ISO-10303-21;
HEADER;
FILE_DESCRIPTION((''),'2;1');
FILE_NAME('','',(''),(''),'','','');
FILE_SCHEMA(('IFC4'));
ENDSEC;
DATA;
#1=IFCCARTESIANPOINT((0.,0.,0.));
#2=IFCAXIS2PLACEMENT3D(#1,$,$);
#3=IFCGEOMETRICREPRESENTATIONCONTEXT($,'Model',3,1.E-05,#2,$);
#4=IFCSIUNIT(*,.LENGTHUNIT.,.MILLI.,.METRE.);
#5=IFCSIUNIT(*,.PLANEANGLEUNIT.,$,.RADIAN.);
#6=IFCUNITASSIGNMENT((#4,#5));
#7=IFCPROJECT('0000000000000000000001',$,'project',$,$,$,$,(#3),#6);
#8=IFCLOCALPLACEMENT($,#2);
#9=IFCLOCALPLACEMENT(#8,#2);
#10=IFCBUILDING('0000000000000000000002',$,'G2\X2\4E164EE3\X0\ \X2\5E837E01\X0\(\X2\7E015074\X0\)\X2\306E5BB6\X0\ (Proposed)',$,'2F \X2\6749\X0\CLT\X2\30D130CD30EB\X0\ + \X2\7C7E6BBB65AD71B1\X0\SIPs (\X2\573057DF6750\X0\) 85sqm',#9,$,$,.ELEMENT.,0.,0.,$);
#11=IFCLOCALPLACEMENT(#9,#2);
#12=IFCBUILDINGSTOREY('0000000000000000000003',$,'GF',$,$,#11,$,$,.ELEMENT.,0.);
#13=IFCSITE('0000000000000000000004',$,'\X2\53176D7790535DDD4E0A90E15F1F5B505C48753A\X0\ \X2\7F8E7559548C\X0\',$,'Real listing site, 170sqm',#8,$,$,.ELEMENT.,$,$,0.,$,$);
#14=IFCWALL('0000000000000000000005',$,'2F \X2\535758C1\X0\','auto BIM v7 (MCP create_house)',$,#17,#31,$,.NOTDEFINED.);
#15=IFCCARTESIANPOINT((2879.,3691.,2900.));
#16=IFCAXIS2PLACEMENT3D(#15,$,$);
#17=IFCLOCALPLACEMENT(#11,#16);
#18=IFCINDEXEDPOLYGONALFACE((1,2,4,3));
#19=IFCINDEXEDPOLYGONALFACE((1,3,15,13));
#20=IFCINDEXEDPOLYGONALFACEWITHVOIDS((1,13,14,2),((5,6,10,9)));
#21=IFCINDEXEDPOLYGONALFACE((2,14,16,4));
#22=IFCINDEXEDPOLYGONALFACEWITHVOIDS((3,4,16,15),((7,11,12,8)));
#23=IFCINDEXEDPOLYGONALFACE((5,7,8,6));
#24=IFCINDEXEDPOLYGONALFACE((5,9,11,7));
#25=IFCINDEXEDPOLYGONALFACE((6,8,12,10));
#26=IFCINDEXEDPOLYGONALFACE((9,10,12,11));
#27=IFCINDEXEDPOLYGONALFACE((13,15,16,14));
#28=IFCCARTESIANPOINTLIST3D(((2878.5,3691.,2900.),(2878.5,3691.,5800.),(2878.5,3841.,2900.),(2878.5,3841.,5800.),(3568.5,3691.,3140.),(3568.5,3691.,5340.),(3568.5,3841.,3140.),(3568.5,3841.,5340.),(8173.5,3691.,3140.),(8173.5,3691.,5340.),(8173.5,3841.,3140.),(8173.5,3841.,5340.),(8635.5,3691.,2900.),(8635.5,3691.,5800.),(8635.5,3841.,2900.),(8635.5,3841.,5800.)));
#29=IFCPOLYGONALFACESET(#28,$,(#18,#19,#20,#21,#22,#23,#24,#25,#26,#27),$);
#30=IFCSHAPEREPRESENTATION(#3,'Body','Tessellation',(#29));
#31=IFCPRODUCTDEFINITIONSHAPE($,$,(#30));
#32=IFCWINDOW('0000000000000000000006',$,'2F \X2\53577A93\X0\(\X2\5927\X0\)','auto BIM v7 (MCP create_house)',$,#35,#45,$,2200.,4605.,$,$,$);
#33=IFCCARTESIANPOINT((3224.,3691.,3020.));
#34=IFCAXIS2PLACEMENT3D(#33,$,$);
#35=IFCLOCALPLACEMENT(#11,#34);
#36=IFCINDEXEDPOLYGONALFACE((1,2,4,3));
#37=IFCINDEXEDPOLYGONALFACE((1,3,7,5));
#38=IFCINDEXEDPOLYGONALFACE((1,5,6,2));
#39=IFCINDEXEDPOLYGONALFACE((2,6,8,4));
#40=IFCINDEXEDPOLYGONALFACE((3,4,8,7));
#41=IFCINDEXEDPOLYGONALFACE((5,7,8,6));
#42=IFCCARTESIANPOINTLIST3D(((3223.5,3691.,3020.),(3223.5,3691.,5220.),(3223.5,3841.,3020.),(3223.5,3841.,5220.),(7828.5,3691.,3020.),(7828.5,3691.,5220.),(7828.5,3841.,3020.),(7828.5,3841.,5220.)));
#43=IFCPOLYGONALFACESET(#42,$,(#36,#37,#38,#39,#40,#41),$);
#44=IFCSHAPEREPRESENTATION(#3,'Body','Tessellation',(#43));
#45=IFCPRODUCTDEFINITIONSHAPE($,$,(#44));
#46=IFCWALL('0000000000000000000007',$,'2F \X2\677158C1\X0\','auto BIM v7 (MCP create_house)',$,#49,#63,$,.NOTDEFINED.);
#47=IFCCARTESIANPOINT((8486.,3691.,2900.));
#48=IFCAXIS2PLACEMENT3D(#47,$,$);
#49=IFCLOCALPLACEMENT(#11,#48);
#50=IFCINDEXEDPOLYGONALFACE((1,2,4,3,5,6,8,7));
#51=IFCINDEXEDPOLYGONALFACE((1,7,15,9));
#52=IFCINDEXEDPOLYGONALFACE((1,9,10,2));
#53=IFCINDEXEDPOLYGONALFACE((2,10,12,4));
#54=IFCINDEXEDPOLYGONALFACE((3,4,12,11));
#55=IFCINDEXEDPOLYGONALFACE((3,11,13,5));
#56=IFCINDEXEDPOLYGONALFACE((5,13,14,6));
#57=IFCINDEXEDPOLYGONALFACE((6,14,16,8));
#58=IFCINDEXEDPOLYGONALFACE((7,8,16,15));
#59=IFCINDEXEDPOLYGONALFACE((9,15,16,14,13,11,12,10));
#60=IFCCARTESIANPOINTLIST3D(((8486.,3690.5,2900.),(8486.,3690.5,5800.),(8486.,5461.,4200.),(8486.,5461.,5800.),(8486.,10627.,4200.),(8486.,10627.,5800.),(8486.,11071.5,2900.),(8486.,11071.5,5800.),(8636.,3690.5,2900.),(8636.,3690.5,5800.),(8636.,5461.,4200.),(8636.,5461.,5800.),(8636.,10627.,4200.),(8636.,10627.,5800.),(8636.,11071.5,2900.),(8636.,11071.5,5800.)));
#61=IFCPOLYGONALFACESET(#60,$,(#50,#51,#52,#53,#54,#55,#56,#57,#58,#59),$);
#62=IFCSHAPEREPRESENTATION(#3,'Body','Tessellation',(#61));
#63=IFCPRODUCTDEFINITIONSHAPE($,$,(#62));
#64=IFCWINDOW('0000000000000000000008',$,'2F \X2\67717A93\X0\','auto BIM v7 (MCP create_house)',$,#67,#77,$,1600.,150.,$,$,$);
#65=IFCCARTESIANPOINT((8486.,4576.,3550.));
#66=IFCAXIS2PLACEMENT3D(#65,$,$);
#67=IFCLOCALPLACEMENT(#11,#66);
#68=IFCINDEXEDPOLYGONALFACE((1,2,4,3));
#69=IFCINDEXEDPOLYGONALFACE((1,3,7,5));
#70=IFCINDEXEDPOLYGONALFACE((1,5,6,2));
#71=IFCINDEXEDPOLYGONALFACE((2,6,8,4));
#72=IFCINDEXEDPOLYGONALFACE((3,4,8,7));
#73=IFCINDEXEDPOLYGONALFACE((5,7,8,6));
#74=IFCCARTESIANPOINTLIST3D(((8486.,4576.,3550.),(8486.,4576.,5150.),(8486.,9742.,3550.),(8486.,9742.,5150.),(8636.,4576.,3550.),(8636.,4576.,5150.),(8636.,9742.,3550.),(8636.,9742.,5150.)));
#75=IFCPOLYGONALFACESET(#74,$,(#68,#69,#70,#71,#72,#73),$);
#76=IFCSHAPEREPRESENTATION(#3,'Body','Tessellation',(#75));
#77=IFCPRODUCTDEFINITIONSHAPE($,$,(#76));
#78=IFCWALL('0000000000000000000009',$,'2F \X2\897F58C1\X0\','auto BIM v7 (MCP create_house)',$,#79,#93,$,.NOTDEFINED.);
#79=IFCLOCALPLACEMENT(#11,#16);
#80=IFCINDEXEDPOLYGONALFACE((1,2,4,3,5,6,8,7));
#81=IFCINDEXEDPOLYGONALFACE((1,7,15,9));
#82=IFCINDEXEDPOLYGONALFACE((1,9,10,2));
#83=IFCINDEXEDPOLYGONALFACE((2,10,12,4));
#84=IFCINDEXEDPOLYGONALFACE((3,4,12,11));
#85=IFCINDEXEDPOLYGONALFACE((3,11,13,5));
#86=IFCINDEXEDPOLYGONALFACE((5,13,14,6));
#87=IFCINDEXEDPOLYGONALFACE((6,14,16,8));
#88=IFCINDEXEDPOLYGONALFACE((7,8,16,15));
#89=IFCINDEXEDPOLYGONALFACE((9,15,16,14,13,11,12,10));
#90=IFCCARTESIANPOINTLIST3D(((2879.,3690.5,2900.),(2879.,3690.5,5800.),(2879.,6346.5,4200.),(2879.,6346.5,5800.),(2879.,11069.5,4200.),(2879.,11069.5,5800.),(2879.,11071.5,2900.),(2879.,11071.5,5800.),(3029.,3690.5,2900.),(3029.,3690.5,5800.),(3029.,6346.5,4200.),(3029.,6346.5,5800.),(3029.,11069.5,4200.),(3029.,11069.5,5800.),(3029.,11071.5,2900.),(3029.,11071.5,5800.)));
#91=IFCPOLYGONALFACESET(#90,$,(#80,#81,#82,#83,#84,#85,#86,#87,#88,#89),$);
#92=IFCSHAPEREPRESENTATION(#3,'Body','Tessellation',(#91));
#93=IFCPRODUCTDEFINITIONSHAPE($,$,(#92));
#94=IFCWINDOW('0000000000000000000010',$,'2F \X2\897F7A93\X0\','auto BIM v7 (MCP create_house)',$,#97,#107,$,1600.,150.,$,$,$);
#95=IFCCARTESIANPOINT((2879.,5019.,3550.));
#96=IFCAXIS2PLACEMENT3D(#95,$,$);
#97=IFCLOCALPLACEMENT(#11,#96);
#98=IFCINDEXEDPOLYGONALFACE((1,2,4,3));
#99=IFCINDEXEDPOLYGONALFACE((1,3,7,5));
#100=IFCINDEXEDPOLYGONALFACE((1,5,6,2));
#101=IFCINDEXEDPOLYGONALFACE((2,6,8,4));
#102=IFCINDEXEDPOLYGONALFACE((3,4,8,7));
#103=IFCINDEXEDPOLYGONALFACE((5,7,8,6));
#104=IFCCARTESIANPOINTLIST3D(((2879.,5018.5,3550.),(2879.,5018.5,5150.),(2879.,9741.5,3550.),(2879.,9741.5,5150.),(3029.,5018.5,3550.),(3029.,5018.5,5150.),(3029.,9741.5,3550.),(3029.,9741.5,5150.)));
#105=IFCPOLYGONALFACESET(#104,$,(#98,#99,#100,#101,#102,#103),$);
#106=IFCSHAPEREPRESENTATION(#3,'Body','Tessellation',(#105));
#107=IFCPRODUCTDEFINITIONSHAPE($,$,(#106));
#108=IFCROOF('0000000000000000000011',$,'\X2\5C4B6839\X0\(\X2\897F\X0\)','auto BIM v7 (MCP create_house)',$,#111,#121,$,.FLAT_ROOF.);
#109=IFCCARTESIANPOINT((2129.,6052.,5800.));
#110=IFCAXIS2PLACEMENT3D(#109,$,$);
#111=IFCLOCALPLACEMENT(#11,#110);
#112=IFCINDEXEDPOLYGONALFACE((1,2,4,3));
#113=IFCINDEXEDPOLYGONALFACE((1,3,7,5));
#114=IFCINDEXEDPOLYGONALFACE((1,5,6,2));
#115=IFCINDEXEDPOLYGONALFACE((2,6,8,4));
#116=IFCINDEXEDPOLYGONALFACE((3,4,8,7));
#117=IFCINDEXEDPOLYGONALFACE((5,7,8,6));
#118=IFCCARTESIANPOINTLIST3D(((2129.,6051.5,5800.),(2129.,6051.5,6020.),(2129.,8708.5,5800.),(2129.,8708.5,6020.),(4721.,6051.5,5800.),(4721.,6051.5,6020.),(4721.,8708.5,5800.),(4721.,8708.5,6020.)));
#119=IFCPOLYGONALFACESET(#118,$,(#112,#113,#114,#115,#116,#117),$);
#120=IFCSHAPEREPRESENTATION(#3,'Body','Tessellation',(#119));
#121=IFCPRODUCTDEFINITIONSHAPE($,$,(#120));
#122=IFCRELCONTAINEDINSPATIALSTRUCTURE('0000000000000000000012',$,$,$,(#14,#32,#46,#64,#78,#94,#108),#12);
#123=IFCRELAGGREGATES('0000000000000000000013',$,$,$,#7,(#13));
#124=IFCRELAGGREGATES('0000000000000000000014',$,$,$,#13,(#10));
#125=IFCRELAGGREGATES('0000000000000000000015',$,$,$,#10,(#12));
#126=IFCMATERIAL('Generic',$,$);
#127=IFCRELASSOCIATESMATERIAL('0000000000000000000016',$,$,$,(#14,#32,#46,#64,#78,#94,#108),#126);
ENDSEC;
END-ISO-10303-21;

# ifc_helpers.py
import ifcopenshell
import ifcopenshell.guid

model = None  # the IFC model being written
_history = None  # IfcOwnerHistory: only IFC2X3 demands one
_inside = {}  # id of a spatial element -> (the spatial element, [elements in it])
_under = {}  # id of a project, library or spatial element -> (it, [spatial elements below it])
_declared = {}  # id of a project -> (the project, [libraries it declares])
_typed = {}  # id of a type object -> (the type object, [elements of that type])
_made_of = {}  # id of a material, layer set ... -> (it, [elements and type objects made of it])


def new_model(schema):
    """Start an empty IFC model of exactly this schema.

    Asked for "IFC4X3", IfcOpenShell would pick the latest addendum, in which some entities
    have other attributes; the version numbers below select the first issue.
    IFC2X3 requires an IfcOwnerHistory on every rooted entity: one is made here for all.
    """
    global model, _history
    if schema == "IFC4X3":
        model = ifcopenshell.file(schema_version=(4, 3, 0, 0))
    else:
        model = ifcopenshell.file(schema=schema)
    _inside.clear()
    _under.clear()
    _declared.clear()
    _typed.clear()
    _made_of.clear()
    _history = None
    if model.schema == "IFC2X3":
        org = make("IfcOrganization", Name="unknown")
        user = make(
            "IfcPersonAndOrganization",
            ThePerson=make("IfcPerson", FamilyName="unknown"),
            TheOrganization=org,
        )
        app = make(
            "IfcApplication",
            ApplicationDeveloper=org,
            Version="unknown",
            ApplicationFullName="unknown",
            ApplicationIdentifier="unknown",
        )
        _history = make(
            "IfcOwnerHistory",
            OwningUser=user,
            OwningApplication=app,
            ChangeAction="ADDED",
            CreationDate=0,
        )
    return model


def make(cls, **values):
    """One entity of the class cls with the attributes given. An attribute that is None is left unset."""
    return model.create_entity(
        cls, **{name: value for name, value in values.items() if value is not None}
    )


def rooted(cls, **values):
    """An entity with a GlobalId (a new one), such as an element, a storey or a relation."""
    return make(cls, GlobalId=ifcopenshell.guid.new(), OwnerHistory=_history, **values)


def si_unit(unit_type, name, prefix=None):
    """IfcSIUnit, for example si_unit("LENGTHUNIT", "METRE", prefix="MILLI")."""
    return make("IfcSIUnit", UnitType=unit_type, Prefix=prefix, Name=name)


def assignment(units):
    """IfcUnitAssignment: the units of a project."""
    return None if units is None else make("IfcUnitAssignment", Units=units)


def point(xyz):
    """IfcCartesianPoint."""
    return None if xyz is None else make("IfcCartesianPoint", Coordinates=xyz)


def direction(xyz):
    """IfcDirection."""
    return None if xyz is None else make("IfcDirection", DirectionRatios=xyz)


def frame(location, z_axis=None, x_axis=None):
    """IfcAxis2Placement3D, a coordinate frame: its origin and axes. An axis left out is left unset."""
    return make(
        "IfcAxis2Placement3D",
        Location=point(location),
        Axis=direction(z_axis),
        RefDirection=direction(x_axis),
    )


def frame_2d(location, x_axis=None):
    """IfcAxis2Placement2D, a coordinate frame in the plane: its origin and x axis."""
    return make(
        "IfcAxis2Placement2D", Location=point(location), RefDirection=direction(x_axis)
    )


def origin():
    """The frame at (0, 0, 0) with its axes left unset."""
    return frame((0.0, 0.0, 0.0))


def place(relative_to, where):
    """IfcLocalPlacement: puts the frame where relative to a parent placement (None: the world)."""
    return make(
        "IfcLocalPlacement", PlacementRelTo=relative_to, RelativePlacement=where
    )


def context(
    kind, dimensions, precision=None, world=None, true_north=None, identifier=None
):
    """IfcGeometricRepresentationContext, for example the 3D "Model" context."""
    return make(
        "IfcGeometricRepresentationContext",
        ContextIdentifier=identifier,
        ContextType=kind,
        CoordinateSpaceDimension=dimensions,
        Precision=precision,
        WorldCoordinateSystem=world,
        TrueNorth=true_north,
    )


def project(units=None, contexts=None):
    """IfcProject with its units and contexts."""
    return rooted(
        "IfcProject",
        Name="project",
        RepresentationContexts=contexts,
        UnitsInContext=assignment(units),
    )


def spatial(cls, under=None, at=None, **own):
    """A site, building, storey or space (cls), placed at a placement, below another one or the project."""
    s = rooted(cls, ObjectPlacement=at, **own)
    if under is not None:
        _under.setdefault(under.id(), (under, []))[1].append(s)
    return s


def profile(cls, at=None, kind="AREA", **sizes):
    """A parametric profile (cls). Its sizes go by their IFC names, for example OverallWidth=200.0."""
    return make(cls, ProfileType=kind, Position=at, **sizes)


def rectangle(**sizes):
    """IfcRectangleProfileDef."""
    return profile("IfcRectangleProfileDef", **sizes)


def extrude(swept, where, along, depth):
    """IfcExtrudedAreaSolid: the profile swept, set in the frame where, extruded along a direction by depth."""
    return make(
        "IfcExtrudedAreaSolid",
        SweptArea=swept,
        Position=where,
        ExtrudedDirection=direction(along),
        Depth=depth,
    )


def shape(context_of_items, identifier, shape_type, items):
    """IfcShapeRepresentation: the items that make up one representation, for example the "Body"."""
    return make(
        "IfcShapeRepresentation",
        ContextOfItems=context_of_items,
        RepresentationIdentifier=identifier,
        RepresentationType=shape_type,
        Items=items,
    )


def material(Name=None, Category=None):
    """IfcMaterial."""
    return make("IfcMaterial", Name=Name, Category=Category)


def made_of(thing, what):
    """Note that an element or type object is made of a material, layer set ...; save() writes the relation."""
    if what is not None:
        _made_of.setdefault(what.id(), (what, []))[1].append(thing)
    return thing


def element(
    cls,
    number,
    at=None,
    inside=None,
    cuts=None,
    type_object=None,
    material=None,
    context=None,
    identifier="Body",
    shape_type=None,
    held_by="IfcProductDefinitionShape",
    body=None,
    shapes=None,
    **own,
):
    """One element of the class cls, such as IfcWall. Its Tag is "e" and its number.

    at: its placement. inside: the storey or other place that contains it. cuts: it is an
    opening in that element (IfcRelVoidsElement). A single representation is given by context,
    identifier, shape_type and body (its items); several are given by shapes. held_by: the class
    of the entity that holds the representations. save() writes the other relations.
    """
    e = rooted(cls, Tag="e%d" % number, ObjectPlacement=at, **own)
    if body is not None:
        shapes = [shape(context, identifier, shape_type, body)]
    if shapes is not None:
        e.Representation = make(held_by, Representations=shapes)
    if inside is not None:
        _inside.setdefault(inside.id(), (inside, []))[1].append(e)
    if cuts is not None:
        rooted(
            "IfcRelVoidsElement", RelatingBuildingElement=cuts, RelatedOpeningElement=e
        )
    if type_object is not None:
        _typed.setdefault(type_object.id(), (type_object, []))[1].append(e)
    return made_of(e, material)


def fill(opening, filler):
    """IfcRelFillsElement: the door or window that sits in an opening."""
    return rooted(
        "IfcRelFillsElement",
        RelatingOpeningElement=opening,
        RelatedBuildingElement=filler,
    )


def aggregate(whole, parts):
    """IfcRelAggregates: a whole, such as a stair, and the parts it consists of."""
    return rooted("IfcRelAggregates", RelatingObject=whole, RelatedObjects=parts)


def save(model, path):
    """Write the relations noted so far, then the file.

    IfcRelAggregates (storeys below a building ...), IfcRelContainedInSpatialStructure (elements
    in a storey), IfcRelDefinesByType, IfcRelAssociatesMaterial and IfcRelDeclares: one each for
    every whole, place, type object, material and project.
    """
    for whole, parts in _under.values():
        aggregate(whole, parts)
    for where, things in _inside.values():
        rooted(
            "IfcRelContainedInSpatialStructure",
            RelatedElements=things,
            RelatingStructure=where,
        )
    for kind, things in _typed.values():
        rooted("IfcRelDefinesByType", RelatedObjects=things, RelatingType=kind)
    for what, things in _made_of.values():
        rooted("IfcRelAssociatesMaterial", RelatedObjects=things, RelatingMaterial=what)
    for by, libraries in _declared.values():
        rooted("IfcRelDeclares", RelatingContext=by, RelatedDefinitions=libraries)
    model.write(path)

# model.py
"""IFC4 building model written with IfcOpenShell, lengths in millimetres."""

from ifc_helpers import new_model, si_unit, frame, frame_2d, origin, place, context, project, spatial, rectangle, extrude, material, element, fill, save


model = new_model("IFC4")

# Units and contexts
model_context = context("Model", 3, precision=1e-05, world=origin())
ifc_project = project(units=[si_unit("LENGTHUNIT", "METRE", prefix="MILLI"), si_unit("PLANEANGLEUNIT", "RADIAN")], contexts=[model_context])

# Site, building, storey
site_placement = place(None, origin())
site = spatial("IfcSite", under=ifc_project, at=site_placement, Name="北海道川上郡弟子屈町 美留和", ObjectType="Real listing site, 170sqm", CompositionType="ELEMENT", RefElevation=0.0)
building_placement = place(site_placement, origin())
building = spatial("IfcBuilding", under=site, at=building_placement, Name="G2世代 広縁(縁側)の家 (Proposed)", ObjectType="2F 杉CLTパネル + 籾殻断熱SIPs (地域材) 85sqm", CompositionType="ELEMENT", ElevationOfRefHeight=0.0, ElevationOfTerrain=0.0)
storey_placement = place(building_placement, origin())
storey = spatial("IfcBuildingStorey", under=building, at=storey_placement, Name="GF", CompositionType="ELEMENT", Elevation=0.0)

# Shared definitions
ifc_material = material(Name="Generic")

# Walls, openings, windows
wall_1_placement = place(storey_placement, frame((2879.0, 3691.0, 2900.0)))
wall_1 = element("IfcWall", 1, at=wall_1_placement, inside=storey, material=ifc_material, Name="2F 南壁", Description="auto BIM v7 (MCP create_house)", PredefinedType="NOTDEFINED", context=model_context, shape_type="SweptSolid", body=[
    extrude(rectangle(XDim=5757.0, YDim=150.0, at=frame_2d((2878.0, 75.0))), frame((2879.0, 3691.0, 2900.0)), (0.0, 0.0, 1.0), 2900.0),
])
opening_1_placement = place(storey_placement, frame((3224.0, 3691.0, 3020.0)))
opening_1 = element("IfcOpeningElement", 2, at=opening_1_placement, cuts=wall_1, PredefinedType="NOTDEFINED", context=model_context, shape_type="SweptSolid", body=[
    extrude(rectangle(XDim=4605.0, YDim=150.0, at=frame_2d((2302.0, 75.0))), frame((3224.0, 3691.0, 3020.0)), (0.0, 0.0, 1.0), 2200.0),
])
window_1_placement = place(storey_placement, frame((3224.0, 3691.0, 3020.0)))
window_1 = element("IfcWindow", 3, at=window_1_placement, inside=storey, material=ifc_material, Name="2F 南窓(大)", Description="auto BIM v7 (MCP create_house)", OverallHeight=2200.0, OverallWidth=4605.0, context=model_context, shape_type="SweptSolid", body=[
    extrude(rectangle(XDim=4605.0, YDim=150.0, at=frame_2d((2302.0, 75.0))), frame((3224.0, 3691.0, 3020.0)), (0.0, 0.0, 1.0), 2200.0),
])
fill(opening_1, window_1)
wall_2_placement = place(storey_placement, frame((8486.0, 3691.0, 2900.0)))
wall_2 = element("IfcWall", 4, at=wall_2_placement, inside=storey, material=ifc_material, Name="2F 東壁", Description="auto BIM v7 (MCP create_house)", PredefinedType="NOTDEFINED", context=model_context, shape_type="SweptSolid", body=[
    extrude(rectangle(XDim=150.0, YDim=7381.0, at=frame_2d((75.0, 3690.0))), frame((8486.0, 3691.0, 2900.0)), (0.0, 0.0, 1.0), 2900.0),
])
opening_2_placement = place(storey_placement, frame((8486.0, 4576.0, 3550.0)))
opening_2 = element("IfcOpeningElement", 5, at=opening_2_placement, cuts=wall_2, PredefinedType="NOTDEFINED", context=model_context, shape_type="SweptSolid", body=[
    extrude(rectangle(XDim=150.0, YDim=5166.0, at=frame_2d((75.0, 2583.0))), frame((8486.0, 4576.0, 3550.0)), (0.0, 0.0, 1.0), 1600.0),
])
window_2_placement = place(storey_placement, frame((8486.0, 4576.0, 3550.0)))
window_2 = element("IfcWindow", 6, at=window_2_placement, inside=storey, material=ifc_material, Name="2F 東窓", Description="auto BIM v7 (MCP create_house)", OverallHeight=1600.0, OverallWidth=150.0, context=model_context, shape_type="SweptSolid", body=[
    extrude(rectangle(XDim=150.0, YDim=5166.0, at=frame_2d((75.0, 2583.0))), frame((8486.0, 4576.0, 3550.0)), (0.0, 0.0, 1.0), 1600.0),
])
fill(opening_2, window_2)
wall_3_placement = place(storey_placement, frame((2879.0, 3691.0, 2900.0)))
wall_3 = element("IfcWall", 7, at=wall_3_placement, inside=storey, material=ifc_material, Name="2F 西壁", Description="auto BIM v7 (MCP create_house)", PredefinedType="NOTDEFINED", context=model_context, shape_type="SweptSolid", body=[
    extrude(rectangle(XDim=150.0, YDim=7381.0, at=frame_2d((75.0, 3690.0))), frame((2879.0, 3691.0, 2900.0)), (0.0, 0.0, 1.0), 2900.0),
])
opening_3_placement = place(storey_placement, frame((2879.0, 5019.0, 3550.0)))
opening_3 = element("IfcOpeningElement", 8, at=opening_3_placement, cuts=wall_3, PredefinedType="NOTDEFINED", context=model_context, shape_type="SweptSolid", body=[
    extrude(rectangle(XDim=150.0, YDim=4723.0, at=frame_2d((75.0, 2361.0))), frame((2879.0, 5019.0, 3550.0)), (0.0, 0.0, 1.0), 1600.0),
])
window_3_placement = place(storey_placement, frame((2879.0, 5019.0, 3550.0)))
window_3 = element("IfcWindow", 9, at=window_3_placement, inside=storey, material=ifc_material, Name="2F 西窓", Description="auto BIM v7 (MCP create_house)", OverallHeight=1600.0, OverallWidth=150.0, context=model_context, shape_type="SweptSolid", body=[
    extrude(rectangle(XDim=150.0, YDim=4723.0, at=frame_2d((75.0, 2361.0))), frame((2879.0, 5019.0, 3550.0)), (0.0, 0.0, 1.0), 1600.0),
])
fill(opening_3, window_3)

# Roof
roof_1_placement = place(storey_placement, frame((2129.0, 6052.0, 5800.0)))
element("IfcRoof", 10, at=roof_1_placement, inside=storey, material=ifc_material, Name="屋根(西)", Description="auto BIM v7 (MCP create_house)", PredefinedType="FLAT_ROOF", context=model_context, shape_type="SweptSolid", body=[
    extrude(rectangle(XDim=2592.0, YDim=2657.0, at=frame_2d((1296.0, 1328.0))), frame((2129.0, 6052.0, 5800.0)), (0.0, 0.0, 1.0), 220.0),
])

save(model, "model.ifc")
